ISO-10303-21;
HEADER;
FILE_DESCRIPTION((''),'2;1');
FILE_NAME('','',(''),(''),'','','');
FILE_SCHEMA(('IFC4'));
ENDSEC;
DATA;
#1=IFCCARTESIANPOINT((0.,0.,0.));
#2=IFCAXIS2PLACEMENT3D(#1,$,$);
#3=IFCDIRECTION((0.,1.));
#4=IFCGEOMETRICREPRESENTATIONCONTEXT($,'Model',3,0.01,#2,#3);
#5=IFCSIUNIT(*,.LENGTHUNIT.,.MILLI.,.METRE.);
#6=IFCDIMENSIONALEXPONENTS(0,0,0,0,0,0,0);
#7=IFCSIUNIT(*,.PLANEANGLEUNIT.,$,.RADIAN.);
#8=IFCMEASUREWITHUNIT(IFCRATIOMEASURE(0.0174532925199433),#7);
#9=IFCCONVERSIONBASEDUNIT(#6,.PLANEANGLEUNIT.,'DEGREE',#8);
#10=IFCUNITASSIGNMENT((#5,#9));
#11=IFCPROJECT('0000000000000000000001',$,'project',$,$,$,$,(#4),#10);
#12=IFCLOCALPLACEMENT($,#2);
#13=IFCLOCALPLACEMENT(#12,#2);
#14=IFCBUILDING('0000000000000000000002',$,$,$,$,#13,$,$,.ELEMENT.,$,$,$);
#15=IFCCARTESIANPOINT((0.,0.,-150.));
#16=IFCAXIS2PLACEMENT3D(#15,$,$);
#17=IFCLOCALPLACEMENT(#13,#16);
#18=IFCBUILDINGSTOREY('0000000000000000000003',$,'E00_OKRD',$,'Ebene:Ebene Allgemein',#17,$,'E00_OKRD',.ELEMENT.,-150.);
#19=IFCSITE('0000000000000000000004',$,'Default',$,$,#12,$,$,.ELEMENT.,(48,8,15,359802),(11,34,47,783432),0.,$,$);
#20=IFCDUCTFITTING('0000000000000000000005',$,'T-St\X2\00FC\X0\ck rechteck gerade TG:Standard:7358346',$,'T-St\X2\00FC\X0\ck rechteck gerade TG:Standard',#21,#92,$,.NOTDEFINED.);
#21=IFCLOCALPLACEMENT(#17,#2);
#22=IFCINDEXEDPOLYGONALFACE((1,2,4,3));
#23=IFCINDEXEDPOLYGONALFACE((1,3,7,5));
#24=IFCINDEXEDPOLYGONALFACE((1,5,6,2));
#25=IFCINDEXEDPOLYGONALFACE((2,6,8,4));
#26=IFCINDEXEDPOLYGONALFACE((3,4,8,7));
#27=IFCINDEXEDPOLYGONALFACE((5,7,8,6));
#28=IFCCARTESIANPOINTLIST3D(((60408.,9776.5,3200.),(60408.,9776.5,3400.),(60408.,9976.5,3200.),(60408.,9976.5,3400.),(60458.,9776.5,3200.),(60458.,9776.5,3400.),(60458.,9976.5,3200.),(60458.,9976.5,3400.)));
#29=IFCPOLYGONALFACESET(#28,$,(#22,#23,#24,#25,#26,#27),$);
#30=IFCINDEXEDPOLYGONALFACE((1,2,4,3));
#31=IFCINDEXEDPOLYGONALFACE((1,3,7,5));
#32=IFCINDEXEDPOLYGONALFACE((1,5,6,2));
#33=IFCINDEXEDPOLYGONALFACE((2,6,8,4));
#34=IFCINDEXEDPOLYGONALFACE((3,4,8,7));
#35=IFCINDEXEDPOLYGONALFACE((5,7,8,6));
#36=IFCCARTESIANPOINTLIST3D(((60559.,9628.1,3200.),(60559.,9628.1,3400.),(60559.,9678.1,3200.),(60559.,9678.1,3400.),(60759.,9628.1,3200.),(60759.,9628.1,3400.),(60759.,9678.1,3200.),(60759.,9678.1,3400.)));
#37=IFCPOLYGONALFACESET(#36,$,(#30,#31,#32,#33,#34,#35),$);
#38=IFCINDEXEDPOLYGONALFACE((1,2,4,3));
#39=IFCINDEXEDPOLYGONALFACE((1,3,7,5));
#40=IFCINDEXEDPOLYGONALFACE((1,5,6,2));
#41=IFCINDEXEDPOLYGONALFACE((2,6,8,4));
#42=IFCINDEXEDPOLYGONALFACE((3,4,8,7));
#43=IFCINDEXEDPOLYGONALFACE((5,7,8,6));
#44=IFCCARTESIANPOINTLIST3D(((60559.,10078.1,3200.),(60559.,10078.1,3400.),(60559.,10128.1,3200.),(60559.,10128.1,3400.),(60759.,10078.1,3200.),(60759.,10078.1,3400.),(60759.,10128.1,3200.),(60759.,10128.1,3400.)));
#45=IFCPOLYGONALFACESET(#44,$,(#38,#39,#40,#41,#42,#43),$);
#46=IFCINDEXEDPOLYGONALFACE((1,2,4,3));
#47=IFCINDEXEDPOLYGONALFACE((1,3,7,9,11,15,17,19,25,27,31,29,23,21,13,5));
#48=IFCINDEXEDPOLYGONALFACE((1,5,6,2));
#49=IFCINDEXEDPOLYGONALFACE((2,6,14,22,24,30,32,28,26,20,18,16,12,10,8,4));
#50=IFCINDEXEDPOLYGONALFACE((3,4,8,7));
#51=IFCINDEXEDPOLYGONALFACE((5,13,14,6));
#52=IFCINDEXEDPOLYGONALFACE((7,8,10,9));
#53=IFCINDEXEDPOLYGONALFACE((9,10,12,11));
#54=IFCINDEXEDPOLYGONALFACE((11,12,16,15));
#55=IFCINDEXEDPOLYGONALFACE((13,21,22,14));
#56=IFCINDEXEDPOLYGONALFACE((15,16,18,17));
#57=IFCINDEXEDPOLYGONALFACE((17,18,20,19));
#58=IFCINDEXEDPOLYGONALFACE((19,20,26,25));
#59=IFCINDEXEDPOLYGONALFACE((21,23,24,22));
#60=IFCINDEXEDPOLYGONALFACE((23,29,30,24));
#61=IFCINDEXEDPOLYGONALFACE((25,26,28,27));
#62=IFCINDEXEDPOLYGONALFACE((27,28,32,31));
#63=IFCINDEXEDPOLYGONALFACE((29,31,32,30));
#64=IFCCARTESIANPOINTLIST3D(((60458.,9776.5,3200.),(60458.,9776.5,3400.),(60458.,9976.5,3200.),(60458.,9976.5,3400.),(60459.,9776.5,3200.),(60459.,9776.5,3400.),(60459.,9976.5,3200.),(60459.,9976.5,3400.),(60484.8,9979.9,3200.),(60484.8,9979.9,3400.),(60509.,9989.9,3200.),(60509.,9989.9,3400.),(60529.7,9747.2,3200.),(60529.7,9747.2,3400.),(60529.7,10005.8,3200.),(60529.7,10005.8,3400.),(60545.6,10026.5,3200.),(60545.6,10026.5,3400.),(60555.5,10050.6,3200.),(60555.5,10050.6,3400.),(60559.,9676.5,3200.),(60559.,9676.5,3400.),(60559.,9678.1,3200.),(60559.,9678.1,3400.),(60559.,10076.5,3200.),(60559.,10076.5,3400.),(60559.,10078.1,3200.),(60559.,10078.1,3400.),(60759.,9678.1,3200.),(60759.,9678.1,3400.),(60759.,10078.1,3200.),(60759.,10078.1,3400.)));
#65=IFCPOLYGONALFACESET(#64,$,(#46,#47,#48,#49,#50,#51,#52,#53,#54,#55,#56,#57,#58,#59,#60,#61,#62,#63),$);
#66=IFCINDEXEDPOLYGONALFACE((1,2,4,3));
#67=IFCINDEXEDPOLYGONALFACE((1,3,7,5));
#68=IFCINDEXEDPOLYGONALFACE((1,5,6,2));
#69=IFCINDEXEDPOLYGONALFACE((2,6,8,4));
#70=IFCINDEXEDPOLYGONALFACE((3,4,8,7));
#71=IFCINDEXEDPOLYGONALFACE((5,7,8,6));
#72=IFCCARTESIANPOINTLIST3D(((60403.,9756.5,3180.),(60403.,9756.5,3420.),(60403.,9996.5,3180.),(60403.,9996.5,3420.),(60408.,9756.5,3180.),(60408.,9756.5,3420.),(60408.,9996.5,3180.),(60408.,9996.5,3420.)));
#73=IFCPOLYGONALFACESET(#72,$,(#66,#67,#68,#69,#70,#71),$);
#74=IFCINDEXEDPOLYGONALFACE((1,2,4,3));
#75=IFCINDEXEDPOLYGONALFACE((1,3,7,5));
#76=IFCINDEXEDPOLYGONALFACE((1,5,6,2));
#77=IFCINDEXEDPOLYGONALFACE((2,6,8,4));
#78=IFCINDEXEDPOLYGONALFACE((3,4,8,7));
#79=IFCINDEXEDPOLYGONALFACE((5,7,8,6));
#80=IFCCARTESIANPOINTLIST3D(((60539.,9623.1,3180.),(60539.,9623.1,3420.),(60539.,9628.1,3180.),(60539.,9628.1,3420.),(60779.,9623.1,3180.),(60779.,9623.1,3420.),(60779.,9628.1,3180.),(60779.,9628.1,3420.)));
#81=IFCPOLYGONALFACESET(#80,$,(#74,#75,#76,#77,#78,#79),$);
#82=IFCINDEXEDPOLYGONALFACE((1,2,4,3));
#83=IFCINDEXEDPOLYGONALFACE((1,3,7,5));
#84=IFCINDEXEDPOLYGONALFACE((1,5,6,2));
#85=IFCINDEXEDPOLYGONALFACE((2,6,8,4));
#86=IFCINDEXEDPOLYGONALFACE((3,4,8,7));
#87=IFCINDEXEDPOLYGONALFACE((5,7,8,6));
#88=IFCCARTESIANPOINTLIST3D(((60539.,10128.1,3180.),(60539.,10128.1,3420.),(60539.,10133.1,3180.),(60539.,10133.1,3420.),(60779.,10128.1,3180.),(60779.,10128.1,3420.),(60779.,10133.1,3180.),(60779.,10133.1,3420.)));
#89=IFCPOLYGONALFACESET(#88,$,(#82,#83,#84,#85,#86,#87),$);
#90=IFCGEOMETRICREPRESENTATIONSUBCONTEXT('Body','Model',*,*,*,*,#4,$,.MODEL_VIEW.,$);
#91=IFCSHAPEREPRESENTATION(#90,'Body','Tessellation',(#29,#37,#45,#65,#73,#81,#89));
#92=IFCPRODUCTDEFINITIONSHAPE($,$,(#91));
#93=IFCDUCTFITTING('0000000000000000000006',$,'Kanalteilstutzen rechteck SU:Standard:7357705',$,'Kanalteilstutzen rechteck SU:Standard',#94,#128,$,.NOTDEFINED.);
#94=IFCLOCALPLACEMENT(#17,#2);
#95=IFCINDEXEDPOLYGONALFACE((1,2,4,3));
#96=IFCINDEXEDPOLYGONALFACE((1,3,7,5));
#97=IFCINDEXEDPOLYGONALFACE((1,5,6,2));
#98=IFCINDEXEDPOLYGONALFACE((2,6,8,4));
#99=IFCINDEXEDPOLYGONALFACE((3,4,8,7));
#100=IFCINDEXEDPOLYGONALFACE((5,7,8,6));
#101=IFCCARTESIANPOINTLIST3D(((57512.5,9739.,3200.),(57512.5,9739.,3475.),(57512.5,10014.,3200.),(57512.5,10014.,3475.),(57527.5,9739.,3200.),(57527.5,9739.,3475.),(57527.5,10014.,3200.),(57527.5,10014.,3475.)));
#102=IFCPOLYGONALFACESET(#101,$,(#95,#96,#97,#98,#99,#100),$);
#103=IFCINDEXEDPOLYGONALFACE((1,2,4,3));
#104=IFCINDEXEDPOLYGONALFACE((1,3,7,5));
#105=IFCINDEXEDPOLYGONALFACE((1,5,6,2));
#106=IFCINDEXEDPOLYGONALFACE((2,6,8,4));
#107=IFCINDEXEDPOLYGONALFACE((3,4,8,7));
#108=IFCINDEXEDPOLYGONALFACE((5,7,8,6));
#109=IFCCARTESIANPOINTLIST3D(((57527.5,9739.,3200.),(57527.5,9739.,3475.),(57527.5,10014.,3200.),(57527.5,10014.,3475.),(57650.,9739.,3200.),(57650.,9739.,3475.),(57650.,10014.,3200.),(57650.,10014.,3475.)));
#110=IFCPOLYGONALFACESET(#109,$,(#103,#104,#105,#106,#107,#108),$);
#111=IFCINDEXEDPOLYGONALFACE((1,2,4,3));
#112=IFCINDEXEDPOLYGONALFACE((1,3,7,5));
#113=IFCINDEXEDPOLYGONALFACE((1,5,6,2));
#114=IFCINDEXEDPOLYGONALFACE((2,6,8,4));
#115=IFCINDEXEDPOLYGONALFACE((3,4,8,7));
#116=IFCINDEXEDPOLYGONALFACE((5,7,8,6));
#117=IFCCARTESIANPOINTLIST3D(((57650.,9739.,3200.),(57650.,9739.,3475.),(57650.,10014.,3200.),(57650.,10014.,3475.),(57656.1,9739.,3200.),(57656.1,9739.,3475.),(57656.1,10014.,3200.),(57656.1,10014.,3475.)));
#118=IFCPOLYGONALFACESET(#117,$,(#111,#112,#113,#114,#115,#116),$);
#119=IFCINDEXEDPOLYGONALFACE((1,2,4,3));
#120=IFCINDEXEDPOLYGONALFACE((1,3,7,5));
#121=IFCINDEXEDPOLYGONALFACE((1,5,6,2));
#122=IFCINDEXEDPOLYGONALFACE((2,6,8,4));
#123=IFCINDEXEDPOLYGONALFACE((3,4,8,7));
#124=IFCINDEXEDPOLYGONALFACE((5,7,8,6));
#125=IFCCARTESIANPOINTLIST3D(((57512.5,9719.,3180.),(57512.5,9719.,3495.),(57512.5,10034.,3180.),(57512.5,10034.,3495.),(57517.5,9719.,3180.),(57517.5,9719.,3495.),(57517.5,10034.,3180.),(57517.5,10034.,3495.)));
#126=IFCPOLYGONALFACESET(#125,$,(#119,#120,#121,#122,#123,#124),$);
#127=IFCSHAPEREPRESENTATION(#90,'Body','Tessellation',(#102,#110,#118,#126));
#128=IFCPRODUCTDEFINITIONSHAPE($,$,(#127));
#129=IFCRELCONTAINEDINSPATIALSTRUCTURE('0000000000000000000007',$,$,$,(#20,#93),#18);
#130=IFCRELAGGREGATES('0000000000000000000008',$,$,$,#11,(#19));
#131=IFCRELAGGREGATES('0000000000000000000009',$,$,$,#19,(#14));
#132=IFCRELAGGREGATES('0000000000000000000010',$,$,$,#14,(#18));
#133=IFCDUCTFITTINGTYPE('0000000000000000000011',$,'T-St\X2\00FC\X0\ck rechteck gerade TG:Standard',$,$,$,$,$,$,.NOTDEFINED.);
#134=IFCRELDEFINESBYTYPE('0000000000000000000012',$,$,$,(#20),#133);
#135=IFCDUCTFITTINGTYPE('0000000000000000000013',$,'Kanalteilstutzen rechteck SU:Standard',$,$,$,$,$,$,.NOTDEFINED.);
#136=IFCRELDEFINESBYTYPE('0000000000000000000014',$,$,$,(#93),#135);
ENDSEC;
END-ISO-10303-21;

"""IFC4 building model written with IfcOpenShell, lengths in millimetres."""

from ifc_helpers import new_model, entity, si_unit, converted_unit, direction, frame, frame_2d, origin, origin_2d_with_axis, place, context, subcontext, project, spatial, polyline, circle_curve, parameter, trimmed, segment, composite_curve, rectangle, outline, extrude, source, transform, mapped, type_object, type_shapes, element, save


model = new_model("IFC4")

# Units and contexts
model_context = context("Model", 3, precision=0.01, world=origin(), true_north=direction((0.0, 1.0)))
body_context = subcontext(model_context, "Body", "Model", "MODEL_VIEW")
ifc_project = project(units=[si_unit("LENGTHUNIT", "METRE", prefix="MILLI"), converted_unit("PLANEANGLEUNIT", "DEGREE", entity("IfcRatioMeasure", 0.0174532925199433), si_unit("PLANEANGLEUNIT", "RADIAN"), dimensions=[0, 0, 0, 0, 0, 0, 0])], contexts=[model_context])

# Site, building, storey
site_placement = place(None, origin())
site = spatial("IfcSite", under=ifc_project, at=site_placement, Name="Default", CompositionType="ELEMENT", RefLatitude=(48, 8, 15, 359802), RefLongitude=(11, 34, 47, 783432), RefElevation=0.0)
building_placement = place(site_placement, origin())
building = spatial("IfcBuilding", under=site, at=building_placement, CompositionType="ELEMENT")
storey_placement = place(building_placement, frame((0.0, 0.0, -150.0)))
storey = spatial("IfcBuildingStorey", under=building, at=storey_placement, Name="E00_OKRD", ObjectType="Ebene:Ebene Allgemein", LongName="E00_OKRD", CompositionType="ELEMENT", Elevation=-150.0)

# Duct fittings
duct_fitting_type_1 = type_object("IfcDuctFittingType", Name="T-Stück rechteck gerade TG:Standard", PredefinedType="NOTDEFINED")
shared_shape_1 = source(origin(), body_context, "Body", "SweptSolid", [
    extrude(rectangle(XDim=50.0, YDim=200.0, at=frame_2d((0.0, 0.0), x_axis=(1.0, 0.0))), frame((0.0, -226.0, -100.0), z_axis=(0.0, 0.0, 1.0), x_axis=(0.0, -1.0, 0.0)), (0.0, 0.0, 1.0), 200.0),
    extrude(rectangle(XDim=50.0, YDim=200.0, at=frame_2d((0.0, 0.0), x_axis=(1.0, 0.0))), frame((223.4, 0.0, -100.0), z_axis=(0.0, 0.0, 1.0), x_axis=(-1.0, 0.0, 0.0)), (0.0, 0.0, 1.0), 200.0),
    extrude(rectangle(XDim=50.0, YDim=200.0, at=frame_2d((0.0, 0.0), x_axis=(1.0, 0.0))), frame((-226.6, 0.0, -100.0)), (0.0, 0.0, 1.0), 200.0),
    extrude(outline(composite_curve([segment(trimmed(circle_curve(frame_2d((-200.6, -99.8), x_axis=(-1.0, 0.0)), 100.0), [parameter(180.0)], [parameter(270.0)], True, "PARAMETER"), False, "CONTINUOUS"), segment(polyline([(-100.6, -99.8), (-100.6, -100.8)]), True, "CONTINUOUS"), segment(polyline([(-100.6, -100.8), (99.4, -100.8)]), True, "CONTINUOUS"), segment(polyline([(99.4, -100.8), (99.4, -99.8)]), True, "CONTINUOUS"), segment(trimmed(circle_curve(frame_2d((199.4, -99.8), x_axis=(-1.0, 0.0)), 100.0), [parameter(270.0)], [parameter(0.0)], True, "PARAMETER"), False, "CONTINUOUS"), segment(polyline([(199.4, 0.2), (201.0, 0.2)]), True, "CONTINUOUS"), segment(polyline([(201.0, 0.2), (201.0, 200.2)]), True, "CONTINUOUS"), segment(polyline([(201.0, 200.2), (-199.0, 200.2)]), True, "CONTINUOUS"), segment(polyline([(-199.0, 200.2), (-199.0, 0.2)]), True, "CONTINUOUS"), segment(polyline([(-199.0, 0.2), (-200.6, 0.2)]), True, "CONTINUOUS")], self_intersect=False)), frame((-0.6, -100.2, -100.0), z_axis=(0.0, 0.0, -1.0), x_axis=(-1.0, 0.0, 0.0)), (0.0, 0.0, -1.0), 200.0),
    extrude(rectangle(XDim=5.0, YDim=240.0, at=frame_2d((0.0, 0.0), x_axis=(1.0, 0.0))), frame((0.0, -253.5, -120.0), z_axis=(0.0, 0.0, 1.0), x_axis=(0.0, 1.0, 0.0)), (0.0, 0.0, 1.0), 240.0),
    extrude(rectangle(XDim=5.0, YDim=240.0, at=origin_2d_with_axis()), frame((250.9, 0.0, -120.0), z_axis=(0.0, 0.0, 1.0), x_axis=(-1.0, 0.0, 0.0)), (0.0, 0.0, 1.0), 240.0),
    extrude(rectangle(XDim=5.0, YDim=240.0, at=origin_2d_with_axis()), frame((-254.1, 0.0, -120.0), z_axis=(0.0, 0.0, 1.0), x_axis=(-1.0, 0.0, 0.0)), (0.0, 0.0, 1.0), 240.0),
])
type_shapes(duct_fitting_type_1, [shared_shape_1])
duct_fitting_1_placement = place(storey_placement, frame((60659.0, 9876.5, 3300.0), z_axis=(0.0, 0.0, 1.0), x_axis=(0.0, -1.0, 0.0)))
element("IfcDuctFitting", 1, at=duct_fitting_1_placement, inside=storey, type_object=duct_fitting_type_1, Name="T-Stück rechteck gerade TG:Standard:7358346", ObjectType="T-Stück rechteck gerade TG:Standard", PredefinedType="NOTDEFINED", context=body_context, shape_type="MappedRepresentation", body=[
    mapped(shared_shape_1, transform((0.0, 0.0, 0.0), scale=1.0)),
])
duct_fitting_type_2 = type_object("IfcDuctFittingType", Name="Kanalteilstutzen rechteck SU:Standard", PredefinedType="NOTDEFINED")
shared_shape_2 = source(origin(), body_context, "Body", "SweptSolid", [
    extrude(rectangle(XDim=275.0, YDim=15.0, at=frame_2d((0.0, 0.0), x_axis=(1.0, 0.0))), frame((130.0, 0.0, -137.5), z_axis=(0.0, 0.0, 1.0), x_axis=(0.0, -1.0, 0.0)), (0.0, 0.0, 1.0), 275.0),
    extrude(rectangle(XDim=275.0, YDim=122.5, at=frame_2d((0.0, 0.0), x_axis=(1.0, 0.0))), frame((61.3, 0.0, -137.5), z_axis=(0.0, 0.0, 1.0), x_axis=(0.0, -1.0, 0.0)), (0.0, 0.0, 1.0), 275.0),
    extrude(rectangle(XDim=275.0, YDim=6.1, at=frame_2d((0.0, 0.0), x_axis=(1.0, 0.0))), frame((-3.0, 0.0, -137.5), z_axis=(0.0, 0.0, 1.0), x_axis=(0.0, -1.0, 0.0)), (0.0, 0.0, 1.0), 275.0),
    extrude(rectangle(XDim=315.0, YDim=5.0, at=origin_2d_with_axis()), frame((135.0, 0.0, -157.5), z_axis=(0.0, 0.0, 1.0), x_axis=(0.0, -1.0, 0.0)), (0.0, 0.0, 1.0), 315.0),
])
type_shapes(duct_fitting_type_2, [shared_shape_2])
duct_fitting_2_placement = place(storey_placement, frame((57650.0, 9876.5, 3337.5), z_axis=(0.0, 0.0, -1.0), x_axis=(-1.0, 0.0, 0.0)))
element("IfcDuctFitting", 2, at=duct_fitting_2_placement, inside=storey, type_object=duct_fitting_type_2, Name="Kanalteilstutzen rechteck SU:Standard:7357705", ObjectType="Kanalteilstutzen rechteck SU:Standard", PredefinedType="NOTDEFINED", context=body_context, shape_type="MappedRepresentation", body=[
    mapped(shared_shape_2, transform((0.0, 0.0, 0.0), scale=1.0)),
])

save(model, "model.ifc")
